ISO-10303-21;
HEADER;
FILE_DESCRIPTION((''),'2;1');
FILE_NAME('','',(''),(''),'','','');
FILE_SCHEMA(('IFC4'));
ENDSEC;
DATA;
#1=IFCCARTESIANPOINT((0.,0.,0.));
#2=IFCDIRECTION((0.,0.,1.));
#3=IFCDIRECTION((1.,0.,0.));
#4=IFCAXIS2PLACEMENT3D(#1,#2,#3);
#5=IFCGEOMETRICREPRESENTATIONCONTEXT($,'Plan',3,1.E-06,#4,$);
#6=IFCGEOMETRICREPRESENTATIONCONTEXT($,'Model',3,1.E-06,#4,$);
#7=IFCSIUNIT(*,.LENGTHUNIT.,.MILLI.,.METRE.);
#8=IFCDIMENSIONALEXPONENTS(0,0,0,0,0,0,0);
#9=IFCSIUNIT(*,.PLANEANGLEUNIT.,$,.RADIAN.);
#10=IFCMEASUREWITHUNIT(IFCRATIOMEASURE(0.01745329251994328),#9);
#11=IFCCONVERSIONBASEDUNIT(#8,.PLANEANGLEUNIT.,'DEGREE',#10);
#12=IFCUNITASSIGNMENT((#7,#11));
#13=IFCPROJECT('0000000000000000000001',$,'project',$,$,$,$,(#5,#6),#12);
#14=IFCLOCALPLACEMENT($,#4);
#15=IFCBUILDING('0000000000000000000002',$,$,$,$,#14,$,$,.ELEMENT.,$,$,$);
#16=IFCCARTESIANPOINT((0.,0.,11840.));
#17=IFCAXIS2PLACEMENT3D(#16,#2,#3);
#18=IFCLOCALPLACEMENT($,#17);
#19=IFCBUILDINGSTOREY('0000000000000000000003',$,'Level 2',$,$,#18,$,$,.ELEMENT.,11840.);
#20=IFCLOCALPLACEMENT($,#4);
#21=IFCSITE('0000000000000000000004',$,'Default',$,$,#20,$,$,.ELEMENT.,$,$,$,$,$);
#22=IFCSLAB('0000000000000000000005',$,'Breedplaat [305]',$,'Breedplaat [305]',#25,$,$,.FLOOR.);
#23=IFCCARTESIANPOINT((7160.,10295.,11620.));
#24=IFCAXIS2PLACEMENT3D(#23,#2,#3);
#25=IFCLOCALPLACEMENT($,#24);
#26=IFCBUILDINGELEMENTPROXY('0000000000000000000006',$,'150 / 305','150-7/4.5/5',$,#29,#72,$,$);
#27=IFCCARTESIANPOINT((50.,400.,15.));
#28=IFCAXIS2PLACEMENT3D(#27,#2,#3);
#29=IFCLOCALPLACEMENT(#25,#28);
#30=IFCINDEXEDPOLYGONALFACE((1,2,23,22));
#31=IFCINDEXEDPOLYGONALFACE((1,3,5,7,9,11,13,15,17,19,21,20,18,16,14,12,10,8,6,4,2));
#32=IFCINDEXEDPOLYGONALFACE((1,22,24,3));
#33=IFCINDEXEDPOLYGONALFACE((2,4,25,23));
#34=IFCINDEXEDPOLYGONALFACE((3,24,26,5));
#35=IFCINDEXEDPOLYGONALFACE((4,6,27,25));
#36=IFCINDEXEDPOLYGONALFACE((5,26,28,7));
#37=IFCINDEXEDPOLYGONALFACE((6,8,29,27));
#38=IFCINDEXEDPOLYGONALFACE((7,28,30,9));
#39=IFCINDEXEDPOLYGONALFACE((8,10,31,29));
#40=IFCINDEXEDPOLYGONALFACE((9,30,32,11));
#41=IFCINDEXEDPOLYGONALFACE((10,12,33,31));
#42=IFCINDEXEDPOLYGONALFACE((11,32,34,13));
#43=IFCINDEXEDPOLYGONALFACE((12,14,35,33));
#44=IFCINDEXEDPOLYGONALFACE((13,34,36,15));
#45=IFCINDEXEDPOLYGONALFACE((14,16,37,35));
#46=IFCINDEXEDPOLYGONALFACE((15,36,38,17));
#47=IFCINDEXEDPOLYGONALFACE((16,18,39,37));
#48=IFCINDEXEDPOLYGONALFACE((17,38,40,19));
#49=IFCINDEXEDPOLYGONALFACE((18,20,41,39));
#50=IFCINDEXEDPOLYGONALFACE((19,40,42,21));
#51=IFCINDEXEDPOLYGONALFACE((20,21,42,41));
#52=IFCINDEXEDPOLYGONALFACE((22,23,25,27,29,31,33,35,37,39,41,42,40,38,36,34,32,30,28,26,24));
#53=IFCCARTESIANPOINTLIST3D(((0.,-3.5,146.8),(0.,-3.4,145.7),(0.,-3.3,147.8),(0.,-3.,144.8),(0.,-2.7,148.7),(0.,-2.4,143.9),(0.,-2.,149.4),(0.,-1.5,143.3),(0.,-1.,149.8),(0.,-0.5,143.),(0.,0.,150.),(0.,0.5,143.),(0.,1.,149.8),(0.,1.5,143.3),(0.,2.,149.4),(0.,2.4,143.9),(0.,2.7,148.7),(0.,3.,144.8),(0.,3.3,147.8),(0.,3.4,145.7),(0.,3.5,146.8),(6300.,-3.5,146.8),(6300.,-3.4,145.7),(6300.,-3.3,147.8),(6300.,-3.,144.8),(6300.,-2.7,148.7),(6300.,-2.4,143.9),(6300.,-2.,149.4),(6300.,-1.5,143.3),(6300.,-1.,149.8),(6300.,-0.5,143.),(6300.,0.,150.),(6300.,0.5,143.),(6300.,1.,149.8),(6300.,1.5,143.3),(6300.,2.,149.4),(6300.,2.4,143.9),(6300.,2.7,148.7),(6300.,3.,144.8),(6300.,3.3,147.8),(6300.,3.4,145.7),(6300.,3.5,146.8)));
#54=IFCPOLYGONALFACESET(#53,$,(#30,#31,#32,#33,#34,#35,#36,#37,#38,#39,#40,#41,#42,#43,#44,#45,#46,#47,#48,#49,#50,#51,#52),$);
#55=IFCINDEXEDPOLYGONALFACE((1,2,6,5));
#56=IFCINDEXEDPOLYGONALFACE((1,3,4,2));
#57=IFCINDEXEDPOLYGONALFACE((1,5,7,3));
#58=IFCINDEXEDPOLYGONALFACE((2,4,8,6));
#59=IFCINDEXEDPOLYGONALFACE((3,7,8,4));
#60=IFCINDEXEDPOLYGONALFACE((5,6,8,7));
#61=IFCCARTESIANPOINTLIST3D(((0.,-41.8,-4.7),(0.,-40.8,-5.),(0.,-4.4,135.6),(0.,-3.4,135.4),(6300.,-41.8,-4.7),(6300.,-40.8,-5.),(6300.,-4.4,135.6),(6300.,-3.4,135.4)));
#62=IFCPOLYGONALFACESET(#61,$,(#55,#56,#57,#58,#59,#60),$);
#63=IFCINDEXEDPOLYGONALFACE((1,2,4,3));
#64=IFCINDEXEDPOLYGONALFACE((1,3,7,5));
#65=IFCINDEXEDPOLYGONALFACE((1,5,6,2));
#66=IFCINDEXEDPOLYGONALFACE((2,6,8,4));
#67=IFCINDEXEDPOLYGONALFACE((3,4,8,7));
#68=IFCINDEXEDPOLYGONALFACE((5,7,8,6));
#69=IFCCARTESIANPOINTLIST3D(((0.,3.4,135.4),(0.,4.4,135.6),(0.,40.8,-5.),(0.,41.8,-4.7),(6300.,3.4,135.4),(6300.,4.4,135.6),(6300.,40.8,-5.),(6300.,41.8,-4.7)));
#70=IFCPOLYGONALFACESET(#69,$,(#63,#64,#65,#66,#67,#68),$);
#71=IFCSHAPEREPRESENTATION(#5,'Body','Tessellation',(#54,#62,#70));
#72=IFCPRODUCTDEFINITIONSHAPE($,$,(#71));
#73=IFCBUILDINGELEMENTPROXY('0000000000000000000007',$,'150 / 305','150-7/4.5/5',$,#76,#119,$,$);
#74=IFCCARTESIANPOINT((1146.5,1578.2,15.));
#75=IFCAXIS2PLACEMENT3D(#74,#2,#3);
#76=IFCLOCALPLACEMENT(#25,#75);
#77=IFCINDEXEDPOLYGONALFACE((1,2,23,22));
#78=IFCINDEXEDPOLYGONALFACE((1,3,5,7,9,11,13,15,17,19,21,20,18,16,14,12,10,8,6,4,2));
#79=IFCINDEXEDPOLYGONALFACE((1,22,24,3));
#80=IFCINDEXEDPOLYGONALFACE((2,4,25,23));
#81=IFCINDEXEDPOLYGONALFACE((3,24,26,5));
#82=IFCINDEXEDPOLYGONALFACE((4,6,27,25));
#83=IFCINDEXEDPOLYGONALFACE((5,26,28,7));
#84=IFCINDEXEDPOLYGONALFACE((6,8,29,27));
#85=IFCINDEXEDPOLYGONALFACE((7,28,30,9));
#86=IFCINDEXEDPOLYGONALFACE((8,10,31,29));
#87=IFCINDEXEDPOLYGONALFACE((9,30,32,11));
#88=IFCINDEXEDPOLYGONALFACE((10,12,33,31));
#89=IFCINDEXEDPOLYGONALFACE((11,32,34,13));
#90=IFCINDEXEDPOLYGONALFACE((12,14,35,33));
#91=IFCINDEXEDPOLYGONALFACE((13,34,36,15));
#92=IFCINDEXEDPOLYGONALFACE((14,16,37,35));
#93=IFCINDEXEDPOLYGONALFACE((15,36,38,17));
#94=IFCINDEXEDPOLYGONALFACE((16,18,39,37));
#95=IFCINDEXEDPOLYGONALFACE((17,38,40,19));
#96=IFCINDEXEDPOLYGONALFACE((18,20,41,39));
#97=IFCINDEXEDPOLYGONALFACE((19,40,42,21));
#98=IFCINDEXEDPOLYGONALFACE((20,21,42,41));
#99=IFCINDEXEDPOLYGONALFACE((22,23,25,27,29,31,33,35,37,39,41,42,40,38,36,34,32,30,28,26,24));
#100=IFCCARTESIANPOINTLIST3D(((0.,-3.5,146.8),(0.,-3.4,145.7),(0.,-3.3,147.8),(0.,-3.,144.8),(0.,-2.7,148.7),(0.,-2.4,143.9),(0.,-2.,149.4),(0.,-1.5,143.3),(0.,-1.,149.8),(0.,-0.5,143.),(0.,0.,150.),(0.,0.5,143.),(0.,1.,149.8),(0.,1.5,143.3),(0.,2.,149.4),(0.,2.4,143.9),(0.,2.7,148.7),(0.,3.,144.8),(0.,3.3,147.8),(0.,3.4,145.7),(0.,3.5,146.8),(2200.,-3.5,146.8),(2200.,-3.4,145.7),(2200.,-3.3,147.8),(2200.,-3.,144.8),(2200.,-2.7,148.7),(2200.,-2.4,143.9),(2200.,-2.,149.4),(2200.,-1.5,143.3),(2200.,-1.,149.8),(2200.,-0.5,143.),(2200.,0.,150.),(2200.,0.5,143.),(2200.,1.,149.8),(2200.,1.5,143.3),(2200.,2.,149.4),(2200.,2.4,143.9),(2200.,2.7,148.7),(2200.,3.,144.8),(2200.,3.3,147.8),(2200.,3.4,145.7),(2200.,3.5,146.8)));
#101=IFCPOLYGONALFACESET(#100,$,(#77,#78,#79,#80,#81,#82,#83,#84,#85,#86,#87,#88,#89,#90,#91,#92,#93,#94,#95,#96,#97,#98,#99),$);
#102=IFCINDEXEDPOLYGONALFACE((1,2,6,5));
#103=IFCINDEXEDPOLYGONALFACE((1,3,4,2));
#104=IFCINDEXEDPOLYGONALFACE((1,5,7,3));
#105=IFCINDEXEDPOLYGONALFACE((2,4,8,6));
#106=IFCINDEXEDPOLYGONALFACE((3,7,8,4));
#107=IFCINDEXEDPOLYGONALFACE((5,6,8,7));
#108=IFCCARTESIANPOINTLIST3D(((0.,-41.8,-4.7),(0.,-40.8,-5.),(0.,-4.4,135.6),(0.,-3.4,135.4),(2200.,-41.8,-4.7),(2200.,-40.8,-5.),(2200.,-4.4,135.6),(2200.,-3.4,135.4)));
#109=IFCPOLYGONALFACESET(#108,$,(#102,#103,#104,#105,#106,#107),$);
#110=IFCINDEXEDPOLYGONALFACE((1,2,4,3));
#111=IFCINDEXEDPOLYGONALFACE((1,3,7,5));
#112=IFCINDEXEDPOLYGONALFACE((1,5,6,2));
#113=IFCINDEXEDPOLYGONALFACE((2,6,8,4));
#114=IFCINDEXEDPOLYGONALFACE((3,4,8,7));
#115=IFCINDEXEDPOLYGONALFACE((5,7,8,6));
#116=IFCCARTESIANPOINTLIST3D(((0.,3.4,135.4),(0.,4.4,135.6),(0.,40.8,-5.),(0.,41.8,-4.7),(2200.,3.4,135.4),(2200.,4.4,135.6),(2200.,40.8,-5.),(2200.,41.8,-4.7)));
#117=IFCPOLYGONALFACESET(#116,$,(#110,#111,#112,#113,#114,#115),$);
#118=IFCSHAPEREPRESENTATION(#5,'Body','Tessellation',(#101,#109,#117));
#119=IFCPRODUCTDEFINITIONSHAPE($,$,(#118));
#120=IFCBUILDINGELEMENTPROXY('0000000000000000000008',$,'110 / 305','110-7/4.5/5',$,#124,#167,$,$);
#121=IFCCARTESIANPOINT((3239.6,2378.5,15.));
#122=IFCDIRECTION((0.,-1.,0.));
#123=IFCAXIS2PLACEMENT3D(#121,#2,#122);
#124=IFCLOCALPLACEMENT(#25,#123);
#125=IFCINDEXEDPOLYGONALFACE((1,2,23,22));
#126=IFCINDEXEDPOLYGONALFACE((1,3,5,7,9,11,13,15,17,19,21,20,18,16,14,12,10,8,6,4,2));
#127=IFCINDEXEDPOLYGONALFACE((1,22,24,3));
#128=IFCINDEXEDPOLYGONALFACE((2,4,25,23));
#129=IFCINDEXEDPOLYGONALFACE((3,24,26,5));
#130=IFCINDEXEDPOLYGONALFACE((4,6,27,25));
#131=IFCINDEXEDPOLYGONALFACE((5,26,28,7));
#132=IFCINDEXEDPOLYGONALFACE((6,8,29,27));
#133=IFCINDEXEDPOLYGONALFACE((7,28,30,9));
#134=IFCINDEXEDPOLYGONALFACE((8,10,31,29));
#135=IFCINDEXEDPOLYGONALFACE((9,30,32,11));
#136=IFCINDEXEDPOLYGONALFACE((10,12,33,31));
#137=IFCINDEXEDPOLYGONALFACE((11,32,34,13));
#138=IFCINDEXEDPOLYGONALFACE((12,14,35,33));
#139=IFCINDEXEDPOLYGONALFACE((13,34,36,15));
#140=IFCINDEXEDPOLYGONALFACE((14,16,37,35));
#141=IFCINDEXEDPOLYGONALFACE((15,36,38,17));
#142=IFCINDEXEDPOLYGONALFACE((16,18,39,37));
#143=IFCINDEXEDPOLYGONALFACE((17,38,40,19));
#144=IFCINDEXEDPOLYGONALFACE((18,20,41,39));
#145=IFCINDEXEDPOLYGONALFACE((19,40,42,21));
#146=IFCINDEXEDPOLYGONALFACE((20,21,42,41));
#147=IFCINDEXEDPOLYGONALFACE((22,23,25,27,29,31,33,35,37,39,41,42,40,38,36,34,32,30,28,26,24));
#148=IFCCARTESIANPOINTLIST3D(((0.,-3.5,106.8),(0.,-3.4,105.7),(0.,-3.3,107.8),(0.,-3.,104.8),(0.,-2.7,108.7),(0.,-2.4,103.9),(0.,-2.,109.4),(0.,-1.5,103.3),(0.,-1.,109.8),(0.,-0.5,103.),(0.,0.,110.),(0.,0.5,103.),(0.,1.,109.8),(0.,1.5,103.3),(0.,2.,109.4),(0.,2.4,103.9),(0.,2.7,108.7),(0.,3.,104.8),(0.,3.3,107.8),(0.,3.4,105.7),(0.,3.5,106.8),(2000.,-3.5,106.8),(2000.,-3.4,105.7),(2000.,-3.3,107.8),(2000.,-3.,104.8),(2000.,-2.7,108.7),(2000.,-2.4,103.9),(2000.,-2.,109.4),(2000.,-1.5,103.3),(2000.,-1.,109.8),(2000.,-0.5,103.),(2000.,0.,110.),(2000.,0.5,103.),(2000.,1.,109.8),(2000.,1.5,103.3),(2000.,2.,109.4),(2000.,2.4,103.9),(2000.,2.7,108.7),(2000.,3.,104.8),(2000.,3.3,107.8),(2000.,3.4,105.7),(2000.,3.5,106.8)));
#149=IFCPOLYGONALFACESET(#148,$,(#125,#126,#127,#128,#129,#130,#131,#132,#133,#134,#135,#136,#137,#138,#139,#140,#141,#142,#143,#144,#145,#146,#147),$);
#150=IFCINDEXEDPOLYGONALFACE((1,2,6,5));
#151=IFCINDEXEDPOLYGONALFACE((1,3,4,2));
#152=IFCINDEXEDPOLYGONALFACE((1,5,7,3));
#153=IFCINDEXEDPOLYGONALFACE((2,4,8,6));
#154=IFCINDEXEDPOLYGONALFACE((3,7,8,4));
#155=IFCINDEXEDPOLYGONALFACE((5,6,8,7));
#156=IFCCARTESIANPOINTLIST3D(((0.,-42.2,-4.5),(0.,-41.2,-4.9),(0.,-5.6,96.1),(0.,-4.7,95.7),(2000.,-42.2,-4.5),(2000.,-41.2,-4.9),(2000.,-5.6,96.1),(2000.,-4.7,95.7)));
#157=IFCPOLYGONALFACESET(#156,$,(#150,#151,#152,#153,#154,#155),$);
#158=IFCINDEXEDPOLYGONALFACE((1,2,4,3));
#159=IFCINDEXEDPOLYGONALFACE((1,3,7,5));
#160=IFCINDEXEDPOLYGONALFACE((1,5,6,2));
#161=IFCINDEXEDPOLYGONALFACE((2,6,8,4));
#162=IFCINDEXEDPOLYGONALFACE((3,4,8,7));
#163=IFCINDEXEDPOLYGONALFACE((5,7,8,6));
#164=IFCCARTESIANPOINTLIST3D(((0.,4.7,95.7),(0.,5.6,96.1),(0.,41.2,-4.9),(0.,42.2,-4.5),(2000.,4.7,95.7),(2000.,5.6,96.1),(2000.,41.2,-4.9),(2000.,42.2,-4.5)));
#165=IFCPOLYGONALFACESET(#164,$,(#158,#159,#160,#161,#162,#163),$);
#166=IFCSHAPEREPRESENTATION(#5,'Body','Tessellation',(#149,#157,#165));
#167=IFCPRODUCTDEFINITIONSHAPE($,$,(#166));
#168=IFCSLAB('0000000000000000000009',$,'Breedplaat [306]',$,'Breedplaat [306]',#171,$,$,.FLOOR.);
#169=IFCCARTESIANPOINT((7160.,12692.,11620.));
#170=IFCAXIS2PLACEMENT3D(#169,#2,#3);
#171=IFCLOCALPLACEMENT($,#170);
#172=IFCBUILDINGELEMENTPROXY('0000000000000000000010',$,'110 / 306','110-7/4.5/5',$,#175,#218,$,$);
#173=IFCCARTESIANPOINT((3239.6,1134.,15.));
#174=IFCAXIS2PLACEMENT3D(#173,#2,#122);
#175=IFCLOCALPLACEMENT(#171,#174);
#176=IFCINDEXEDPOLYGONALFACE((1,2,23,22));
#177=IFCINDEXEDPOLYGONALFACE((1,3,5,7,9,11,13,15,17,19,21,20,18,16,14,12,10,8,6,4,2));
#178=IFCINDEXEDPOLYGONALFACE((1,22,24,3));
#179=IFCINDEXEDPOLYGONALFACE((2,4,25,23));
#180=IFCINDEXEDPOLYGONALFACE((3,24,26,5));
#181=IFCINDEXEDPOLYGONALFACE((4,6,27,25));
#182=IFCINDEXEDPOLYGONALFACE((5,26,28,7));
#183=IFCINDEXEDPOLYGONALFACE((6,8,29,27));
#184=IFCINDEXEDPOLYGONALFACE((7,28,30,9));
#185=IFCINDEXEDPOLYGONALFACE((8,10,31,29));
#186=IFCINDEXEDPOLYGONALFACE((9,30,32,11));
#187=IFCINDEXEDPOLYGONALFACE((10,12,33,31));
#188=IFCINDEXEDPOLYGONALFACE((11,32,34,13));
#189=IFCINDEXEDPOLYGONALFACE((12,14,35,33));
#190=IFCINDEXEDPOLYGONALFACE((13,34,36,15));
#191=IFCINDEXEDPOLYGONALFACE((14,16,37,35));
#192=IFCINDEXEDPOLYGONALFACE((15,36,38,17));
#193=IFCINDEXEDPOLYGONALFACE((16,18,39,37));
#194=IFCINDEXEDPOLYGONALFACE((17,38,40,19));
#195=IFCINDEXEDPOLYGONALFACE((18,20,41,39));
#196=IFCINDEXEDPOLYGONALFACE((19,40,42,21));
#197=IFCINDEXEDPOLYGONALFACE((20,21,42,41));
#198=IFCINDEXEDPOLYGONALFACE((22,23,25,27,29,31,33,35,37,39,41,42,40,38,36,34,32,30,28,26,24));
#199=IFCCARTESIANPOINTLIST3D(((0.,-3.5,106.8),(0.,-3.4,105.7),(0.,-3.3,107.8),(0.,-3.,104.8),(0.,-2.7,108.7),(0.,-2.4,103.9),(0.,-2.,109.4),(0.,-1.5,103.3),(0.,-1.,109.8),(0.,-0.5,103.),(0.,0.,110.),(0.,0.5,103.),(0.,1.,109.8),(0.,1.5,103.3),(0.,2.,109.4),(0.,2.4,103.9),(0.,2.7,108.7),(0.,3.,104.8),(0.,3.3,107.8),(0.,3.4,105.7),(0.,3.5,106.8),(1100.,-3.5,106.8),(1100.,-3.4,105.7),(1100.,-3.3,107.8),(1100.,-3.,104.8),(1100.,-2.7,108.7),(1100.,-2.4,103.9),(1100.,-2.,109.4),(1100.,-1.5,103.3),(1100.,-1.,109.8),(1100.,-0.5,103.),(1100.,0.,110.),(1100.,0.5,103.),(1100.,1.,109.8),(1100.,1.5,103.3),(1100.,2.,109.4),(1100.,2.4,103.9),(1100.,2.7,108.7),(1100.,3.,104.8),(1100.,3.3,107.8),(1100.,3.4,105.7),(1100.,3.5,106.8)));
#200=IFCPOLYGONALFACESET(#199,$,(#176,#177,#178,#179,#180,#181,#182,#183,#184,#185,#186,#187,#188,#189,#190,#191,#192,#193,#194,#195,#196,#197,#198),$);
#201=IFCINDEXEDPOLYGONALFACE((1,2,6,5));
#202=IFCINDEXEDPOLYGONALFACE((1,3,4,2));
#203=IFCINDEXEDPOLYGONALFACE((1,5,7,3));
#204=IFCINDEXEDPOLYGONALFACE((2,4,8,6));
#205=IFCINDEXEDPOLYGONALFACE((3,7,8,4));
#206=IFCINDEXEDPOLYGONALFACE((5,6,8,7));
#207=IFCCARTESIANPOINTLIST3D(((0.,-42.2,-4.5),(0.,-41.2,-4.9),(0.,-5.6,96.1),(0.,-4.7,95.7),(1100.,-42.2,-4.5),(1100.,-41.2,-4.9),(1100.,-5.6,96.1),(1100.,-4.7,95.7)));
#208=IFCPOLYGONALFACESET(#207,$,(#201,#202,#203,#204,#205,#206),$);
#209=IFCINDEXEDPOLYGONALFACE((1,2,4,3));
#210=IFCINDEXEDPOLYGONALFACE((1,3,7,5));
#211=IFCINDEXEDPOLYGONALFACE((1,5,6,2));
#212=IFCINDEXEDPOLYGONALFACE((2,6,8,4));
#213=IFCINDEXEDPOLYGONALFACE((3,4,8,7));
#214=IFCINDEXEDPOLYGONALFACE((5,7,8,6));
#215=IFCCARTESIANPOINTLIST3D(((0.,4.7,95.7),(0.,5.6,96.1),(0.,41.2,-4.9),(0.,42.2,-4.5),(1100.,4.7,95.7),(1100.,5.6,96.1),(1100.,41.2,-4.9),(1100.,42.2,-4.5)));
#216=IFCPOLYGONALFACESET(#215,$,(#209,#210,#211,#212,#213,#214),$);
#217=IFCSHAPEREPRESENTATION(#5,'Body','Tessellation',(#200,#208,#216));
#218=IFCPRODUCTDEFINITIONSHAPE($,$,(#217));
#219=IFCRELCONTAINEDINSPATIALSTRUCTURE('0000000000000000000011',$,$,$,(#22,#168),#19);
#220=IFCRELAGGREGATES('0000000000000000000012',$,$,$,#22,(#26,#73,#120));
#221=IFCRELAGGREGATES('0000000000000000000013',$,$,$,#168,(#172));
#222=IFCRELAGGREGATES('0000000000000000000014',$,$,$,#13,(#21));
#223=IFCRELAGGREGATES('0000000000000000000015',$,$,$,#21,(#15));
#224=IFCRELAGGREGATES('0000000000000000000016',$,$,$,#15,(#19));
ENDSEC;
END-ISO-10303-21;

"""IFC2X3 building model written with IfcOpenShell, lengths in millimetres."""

from ifc_helpers import new_model, entity, si_unit, converted_unit, frame, origin_with_axes, origin_2d_with_axis, place, context, project, spatial, rectangle, circle, extrude, element, aggregate, save


model = new_model("IFC2X3")

# Units and contexts
plan_context = context("Plan", 3, precision=1e-06, world=origin_with_axes())
model_context = context("Model", 3, precision=1e-06, world=origin_with_axes())
ifc_project = project(units=[si_unit("LENGTHUNIT", "METRE", prefix="MILLI"), converted_unit("PLANEANGLEUNIT", "DEGREE", entity("IfcRatioMeasure", 0.01745329251994328), si_unit("PLANEANGLEUNIT", "RADIAN"), dimensions=[0, 0, 0, 0, 0, 0, 0])], contexts=[plan_context, model_context])

# Site, building, storey
site_placement = place(None, origin_with_axes())
site = spatial("IfcSite", under=ifc_project, at=site_placement, Name="Default", CompositionType="ELEMENT")
building_placement = place(None, origin_with_axes())
building = spatial("IfcBuilding", under=site, at=building_placement, CompositionType="ELEMENT")
storey_placement = place(None, frame((0.0, 0.0, 11840.0), z_axis=(0.0, 0.0, 1.0), x_axis=(1.0, 0.0, 0.0)))
storey = spatial("IfcBuildingStorey", under=building, at=storey_placement, Name="Level 2", CompositionType="ELEMENT", Elevation=11840.0)

# Slabs, building element proxies
slab_1_placement = place(None, frame((7160.0, 10295.0, 11620.0), z_axis=(0.0, 0.0, 1.0), x_axis=(1.0, 0.0, 0.0)))
slab_1 = element("IfcSlab", 1, at=slab_1_placement, inside=storey, Name="Breedplaat [305]", ObjectType="Breedplaat [305]", PredefinedType="FLOOR")
proxy_1_placement = place(slab_1_placement, frame((50.0, 400.0, 15.0), z_axis=(0.0, 0.0, 1.0), x_axis=(1.0, 0.0, 0.0)))
proxy_1 = element("IfcBuildingElementProxy", 2, at=proxy_1_placement, Name="150 / 305", Description="150-7/4.5/5", context=plan_context, shape_type="SweptSolid", body=[
    extrude(circle(Radius=3.5, at=origin_2d_with_axis()), frame((0.0, 0.0, 146.5), z_axis=(1.0, 0.0, 0.0), x_axis=(0.0, 0.0, 1.0)), (0.0, 0.0, 1.0), 6300.0),
    extrude(rectangle(XDim=145.2, YDim=1.0, at=origin_2d_with_axis()), frame((0.0, -22.6, 65.3), z_axis=(1.0, 0.0, 0.0), x_axis=(0.0, 0.257663, 0.966235)), (0.0, 0.0, 1.0), 6300.0),
    extrude(rectangle(XDim=145.2, YDim=1.0, at=origin_2d_with_axis()), frame((0.0, 22.6, 65.3), z_axis=(1.0, 0.0, 0.0), x_axis=(0.0, -0.257663, 0.966235)), (0.0, 0.0, 1.0), 6300.0),
])
proxy_2_placement = place(slab_1_placement, frame((1146.5, 1578.2, 15.0), z_axis=(0.0, 0.0, 1.0), x_axis=(1.0, 0.0, 0.0)))
proxy_2 = element("IfcBuildingElementProxy", 3, at=proxy_2_placement, Name="150 / 305", Description="150-7/4.5/5", context=plan_context, shape_type="SweptSolid", body=[
    extrude(circle(Radius=3.5, at=origin_2d_with_axis()), frame((0.0, 0.0, 146.5), z_axis=(1.0, 0.0, 0.0), x_axis=(0.0, 0.0, 1.0)), (0.0, 0.0, 1.0), 2200.0),
    extrude(rectangle(XDim=145.2, YDim=1.0, at=origin_2d_with_axis()), frame((0.0, -22.6, 65.3), z_axis=(1.0, 0.0, 0.0), x_axis=(0.0, 0.257663, 0.966235)), (0.0, 0.0, 1.0), 2200.0),
    extrude(rectangle(XDim=145.2, YDim=1.0, at=origin_2d_with_axis()), frame((0.0, 22.6, 65.3), z_axis=(1.0, 0.0, 0.0), x_axis=(0.0, -0.257663, 0.966235)), (0.0, 0.0, 1.0), 2200.0),
])
proxy_3_placement = place(slab_1_placement, frame((3239.6, 2378.5, 15.0), z_axis=(0.0, 0.0, 1.0), x_axis=(0.0, -1.0, 0.0)))
proxy_3 = element("IfcBuildingElementProxy", 4, at=proxy_3_placement, Name="110 / 305", Description="110-7/4.5/5", context=plan_context, shape_type="SweptSolid", body=[
    extrude(circle(Radius=3.5, at=origin_2d_with_axis()), frame((0.0, 0.0, 106.5), z_axis=(1.0, 0.0, 0.0), x_axis=(0.0, 0.0, 1.0)), (0.0, 0.0, 1.0), 2000.0),
    extrude(rectangle(XDim=107.0, YDim=1.0, at=origin_2d_with_axis()), frame((0.0, -23.4, 45.6), z_axis=(1.0, 0.0, 0.0), x_axis=(0.0, 0.341743, 0.939793)), (0.0, 0.0, 1.0), 2000.0),
    extrude(rectangle(XDim=107.0, YDim=1.0, at=origin_2d_with_axis()), frame((0.0, 23.4, 45.6), z_axis=(1.0, 0.0, 0.0), x_axis=(0.0, -0.341743, 0.939793)), (0.0, 0.0, 1.0), 2000.0),
])
aggregate(slab_1, [proxy_1, proxy_2, proxy_3])
slab_2_placement = place(None, frame((7160.0, 12692.0, 11620.0), z_axis=(0.0, 0.0, 1.0), x_axis=(1.0, 0.0, 0.0)))
slab_2 = element("IfcSlab", 5, at=slab_2_placement, inside=storey, Name="Breedplaat [306]", ObjectType="Breedplaat [306]", PredefinedType="FLOOR")
proxy_4_placement = place(slab_2_placement, frame((3239.6, 1134.0, 15.0), z_axis=(0.0, 0.0, 1.0), x_axis=(0.0, -1.0, 0.0)))
proxy_4 = element("IfcBuildingElementProxy", 6, at=proxy_4_placement, Name="110 / 306", Description="110-7/4.5/5", context=plan_context, shape_type="SweptSolid", body=[
    extrude(circle(Radius=3.5, at=origin_2d_with_axis()), frame((0.0, 0.0, 106.5), z_axis=(1.0, 0.0, 0.0), x_axis=(0.0, 0.0, 1.0)), (0.0, 0.0, 1.0), 1100.0),
    extrude(rectangle(XDim=107.0, YDim=1.0, at=origin_2d_with_axis()), frame((0.0, -23.4, 45.6), z_axis=(1.0, 0.0, 0.0), x_axis=(0.0, 0.341743, 0.939793)), (0.0, 0.0, 1.0), 1100.0),
    extrude(rectangle(XDim=107.0, YDim=1.0, at=origin_2d_with_axis()), frame((0.0, 23.4, 45.6), z_axis=(1.0, 0.0, 0.0), x_axis=(0.0, -0.341743, 0.939793)), (0.0, 0.0, 1.0), 1100.0),
])
aggregate(slab_2, [proxy_4])

save(model, "model.ifc")
